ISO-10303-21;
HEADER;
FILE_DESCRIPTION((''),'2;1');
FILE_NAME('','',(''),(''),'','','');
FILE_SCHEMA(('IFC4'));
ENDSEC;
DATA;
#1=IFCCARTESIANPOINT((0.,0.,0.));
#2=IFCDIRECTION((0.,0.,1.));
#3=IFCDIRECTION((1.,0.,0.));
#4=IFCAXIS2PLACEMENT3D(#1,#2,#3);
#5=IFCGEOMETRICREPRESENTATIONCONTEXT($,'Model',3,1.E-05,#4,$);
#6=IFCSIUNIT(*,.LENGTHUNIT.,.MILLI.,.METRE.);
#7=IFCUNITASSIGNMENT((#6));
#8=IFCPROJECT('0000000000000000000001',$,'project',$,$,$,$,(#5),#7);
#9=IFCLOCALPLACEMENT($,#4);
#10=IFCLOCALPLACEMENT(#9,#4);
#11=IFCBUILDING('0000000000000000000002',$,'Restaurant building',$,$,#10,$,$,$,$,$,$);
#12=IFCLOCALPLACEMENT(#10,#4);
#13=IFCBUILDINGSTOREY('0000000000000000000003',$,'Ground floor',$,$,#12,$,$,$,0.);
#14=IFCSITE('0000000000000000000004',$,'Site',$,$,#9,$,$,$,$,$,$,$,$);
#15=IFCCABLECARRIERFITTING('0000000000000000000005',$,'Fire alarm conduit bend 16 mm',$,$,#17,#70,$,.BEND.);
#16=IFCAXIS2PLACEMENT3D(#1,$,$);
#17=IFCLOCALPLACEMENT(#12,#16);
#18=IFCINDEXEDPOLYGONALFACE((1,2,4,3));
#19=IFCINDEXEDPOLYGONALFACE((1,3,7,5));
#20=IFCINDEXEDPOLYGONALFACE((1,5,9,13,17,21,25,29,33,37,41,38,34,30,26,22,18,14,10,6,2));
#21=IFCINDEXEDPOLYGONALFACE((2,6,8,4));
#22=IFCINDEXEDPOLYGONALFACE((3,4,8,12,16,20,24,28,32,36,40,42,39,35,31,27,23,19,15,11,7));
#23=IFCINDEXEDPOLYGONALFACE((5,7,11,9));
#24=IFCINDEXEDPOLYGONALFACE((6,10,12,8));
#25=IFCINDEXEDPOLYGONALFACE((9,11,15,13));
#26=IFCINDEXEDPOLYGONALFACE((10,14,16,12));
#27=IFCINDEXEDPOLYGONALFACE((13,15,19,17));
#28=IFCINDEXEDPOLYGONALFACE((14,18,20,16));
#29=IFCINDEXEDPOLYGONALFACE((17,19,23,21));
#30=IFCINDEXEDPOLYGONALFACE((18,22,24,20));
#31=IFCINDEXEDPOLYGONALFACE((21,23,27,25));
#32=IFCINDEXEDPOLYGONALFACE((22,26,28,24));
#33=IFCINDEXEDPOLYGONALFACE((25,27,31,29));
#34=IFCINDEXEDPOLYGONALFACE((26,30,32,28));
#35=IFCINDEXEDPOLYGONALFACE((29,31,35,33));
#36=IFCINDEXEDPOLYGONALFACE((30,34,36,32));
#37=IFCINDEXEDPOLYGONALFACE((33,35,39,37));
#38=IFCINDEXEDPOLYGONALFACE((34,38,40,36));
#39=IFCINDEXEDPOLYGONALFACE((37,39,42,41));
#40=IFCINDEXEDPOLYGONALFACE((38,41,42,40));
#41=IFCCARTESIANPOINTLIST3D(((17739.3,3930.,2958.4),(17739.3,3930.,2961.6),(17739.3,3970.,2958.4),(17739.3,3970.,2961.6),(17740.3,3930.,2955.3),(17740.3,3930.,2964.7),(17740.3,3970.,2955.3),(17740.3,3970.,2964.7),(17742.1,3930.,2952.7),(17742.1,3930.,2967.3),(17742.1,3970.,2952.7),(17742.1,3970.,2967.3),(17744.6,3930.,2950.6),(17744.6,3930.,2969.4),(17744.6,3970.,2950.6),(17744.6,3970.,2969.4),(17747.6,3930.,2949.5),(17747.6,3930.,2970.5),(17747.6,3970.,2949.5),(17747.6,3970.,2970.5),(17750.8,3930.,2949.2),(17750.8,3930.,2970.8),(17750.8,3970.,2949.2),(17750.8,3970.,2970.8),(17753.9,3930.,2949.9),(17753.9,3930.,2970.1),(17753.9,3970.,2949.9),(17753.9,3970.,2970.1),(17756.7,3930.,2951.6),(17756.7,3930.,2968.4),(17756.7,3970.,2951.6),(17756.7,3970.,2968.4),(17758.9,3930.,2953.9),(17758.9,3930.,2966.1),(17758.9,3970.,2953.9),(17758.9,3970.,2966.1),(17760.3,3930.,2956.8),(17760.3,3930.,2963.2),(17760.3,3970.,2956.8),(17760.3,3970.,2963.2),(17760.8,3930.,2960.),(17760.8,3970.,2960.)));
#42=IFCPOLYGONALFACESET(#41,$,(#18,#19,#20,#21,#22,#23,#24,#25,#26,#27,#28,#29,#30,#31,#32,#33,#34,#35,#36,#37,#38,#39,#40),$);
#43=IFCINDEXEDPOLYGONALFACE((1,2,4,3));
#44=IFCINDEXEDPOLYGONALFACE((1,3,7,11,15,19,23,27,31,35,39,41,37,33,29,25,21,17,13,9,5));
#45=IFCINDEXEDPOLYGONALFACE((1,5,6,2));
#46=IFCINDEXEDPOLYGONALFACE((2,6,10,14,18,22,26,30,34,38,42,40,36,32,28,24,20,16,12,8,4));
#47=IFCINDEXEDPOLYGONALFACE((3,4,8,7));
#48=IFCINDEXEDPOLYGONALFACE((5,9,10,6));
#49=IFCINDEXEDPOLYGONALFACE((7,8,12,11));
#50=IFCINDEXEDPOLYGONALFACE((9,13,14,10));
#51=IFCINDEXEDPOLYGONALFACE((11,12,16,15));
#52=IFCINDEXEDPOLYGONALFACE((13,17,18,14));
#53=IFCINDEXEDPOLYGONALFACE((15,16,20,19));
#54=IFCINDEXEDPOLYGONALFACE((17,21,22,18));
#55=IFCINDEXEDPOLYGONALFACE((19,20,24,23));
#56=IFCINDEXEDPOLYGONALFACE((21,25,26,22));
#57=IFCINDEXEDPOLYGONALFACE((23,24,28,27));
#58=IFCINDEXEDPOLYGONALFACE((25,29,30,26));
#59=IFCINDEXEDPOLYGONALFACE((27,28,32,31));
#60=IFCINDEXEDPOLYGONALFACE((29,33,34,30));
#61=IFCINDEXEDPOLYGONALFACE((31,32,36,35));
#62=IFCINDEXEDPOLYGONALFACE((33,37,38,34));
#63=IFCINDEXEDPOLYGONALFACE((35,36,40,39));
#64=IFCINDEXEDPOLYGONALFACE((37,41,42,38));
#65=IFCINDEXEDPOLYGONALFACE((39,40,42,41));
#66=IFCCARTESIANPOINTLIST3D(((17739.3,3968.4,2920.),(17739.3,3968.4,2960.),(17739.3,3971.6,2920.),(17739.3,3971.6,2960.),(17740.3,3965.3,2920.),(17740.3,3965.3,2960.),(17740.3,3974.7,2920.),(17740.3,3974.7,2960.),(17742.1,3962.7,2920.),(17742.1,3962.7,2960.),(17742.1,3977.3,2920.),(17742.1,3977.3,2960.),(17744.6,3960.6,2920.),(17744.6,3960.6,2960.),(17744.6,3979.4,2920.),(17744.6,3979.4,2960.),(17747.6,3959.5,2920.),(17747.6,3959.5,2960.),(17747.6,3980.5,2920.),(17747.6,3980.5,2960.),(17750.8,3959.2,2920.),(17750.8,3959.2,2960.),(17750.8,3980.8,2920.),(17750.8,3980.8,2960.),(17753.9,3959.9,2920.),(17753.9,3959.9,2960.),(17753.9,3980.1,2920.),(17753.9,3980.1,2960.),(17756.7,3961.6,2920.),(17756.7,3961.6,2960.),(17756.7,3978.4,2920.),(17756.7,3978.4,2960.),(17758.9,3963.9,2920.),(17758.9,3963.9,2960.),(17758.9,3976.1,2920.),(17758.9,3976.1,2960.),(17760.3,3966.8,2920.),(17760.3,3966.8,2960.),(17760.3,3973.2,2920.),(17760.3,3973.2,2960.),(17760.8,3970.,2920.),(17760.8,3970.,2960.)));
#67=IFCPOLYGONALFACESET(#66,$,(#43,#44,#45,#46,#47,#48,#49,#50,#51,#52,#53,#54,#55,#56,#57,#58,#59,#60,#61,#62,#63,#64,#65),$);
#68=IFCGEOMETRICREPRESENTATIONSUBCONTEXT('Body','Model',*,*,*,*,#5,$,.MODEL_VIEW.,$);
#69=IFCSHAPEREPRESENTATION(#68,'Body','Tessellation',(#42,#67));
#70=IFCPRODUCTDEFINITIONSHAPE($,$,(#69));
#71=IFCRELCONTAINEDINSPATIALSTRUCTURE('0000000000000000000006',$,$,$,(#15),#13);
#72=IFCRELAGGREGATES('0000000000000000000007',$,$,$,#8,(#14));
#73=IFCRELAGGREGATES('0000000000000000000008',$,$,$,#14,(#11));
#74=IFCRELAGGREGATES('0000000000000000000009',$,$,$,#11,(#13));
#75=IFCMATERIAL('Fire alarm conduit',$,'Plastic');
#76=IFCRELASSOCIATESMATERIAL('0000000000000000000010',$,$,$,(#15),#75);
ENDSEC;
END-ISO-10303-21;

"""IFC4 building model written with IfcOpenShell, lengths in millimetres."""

from ifc_helpers import new_model, si_unit, frame, origin_with_axes, origin_2d, place, context, subcontext, project, spatial, circle, extrude, material, element, save


model = new_model("IFC4")

# Units and contexts
model_context = context("Model", 3, precision=1e-05, world=origin_with_axes())
body_context = subcontext(model_context, "Body", "Model", "MODEL_VIEW")
ifc_project = project(units=[si_unit("LENGTHUNIT", "METRE", prefix="MILLI")], contexts=[model_context])

# Site, building, storey
site_placement = place(None, origin_with_axes())
site = spatial("IfcSite", under=ifc_project, at=site_placement, Name="Site")
building_placement = place(site_placement, origin_with_axes())
building = spatial("IfcBuilding", under=site, at=building_placement, Name="Restaurant building")
storey_placement = place(building_placement, origin_with_axes())
storey = spatial("IfcBuildingStorey", under=building, at=storey_placement, Name="Ground floor", Elevation=0.0)

# Shared definitions
ifc_material_1 = material(Name="Fire alarm conduit", Category="Plastic")

# Cable carrier fitting
cable_carrier_fitting_1_placement = place(storey_placement, frame((17750.0, 3970.0, 2960.0)))
element("IfcCableCarrierFitting", 1, at=cable_carrier_fitting_1_placement, inside=storey, material=ifc_material_1, Name="Fire alarm conduit bend 16 mm", PredefinedType="BEND", context=body_context, shape_type="SweptSolid", body=[
    extrude(circle(Radius=10.8, at=origin_2d()), frame((0.0, 0.0, 0.0), z_axis=(0.0, -1.0, 0.0), x_axis=(1.0, 0.0, 0.0)), (0.0, 0.0, 1.0), 40.0),
    extrude(circle(Radius=10.8, at=origin_2d()), frame((0.0, 0.0, 0.0), z_axis=(0.0, 0.0, -1.0), x_axis=(1.0, 0.0, 0.0)), (0.0, 0.0, 1.0), 40.0),
])

save(model, "model.ifc")
